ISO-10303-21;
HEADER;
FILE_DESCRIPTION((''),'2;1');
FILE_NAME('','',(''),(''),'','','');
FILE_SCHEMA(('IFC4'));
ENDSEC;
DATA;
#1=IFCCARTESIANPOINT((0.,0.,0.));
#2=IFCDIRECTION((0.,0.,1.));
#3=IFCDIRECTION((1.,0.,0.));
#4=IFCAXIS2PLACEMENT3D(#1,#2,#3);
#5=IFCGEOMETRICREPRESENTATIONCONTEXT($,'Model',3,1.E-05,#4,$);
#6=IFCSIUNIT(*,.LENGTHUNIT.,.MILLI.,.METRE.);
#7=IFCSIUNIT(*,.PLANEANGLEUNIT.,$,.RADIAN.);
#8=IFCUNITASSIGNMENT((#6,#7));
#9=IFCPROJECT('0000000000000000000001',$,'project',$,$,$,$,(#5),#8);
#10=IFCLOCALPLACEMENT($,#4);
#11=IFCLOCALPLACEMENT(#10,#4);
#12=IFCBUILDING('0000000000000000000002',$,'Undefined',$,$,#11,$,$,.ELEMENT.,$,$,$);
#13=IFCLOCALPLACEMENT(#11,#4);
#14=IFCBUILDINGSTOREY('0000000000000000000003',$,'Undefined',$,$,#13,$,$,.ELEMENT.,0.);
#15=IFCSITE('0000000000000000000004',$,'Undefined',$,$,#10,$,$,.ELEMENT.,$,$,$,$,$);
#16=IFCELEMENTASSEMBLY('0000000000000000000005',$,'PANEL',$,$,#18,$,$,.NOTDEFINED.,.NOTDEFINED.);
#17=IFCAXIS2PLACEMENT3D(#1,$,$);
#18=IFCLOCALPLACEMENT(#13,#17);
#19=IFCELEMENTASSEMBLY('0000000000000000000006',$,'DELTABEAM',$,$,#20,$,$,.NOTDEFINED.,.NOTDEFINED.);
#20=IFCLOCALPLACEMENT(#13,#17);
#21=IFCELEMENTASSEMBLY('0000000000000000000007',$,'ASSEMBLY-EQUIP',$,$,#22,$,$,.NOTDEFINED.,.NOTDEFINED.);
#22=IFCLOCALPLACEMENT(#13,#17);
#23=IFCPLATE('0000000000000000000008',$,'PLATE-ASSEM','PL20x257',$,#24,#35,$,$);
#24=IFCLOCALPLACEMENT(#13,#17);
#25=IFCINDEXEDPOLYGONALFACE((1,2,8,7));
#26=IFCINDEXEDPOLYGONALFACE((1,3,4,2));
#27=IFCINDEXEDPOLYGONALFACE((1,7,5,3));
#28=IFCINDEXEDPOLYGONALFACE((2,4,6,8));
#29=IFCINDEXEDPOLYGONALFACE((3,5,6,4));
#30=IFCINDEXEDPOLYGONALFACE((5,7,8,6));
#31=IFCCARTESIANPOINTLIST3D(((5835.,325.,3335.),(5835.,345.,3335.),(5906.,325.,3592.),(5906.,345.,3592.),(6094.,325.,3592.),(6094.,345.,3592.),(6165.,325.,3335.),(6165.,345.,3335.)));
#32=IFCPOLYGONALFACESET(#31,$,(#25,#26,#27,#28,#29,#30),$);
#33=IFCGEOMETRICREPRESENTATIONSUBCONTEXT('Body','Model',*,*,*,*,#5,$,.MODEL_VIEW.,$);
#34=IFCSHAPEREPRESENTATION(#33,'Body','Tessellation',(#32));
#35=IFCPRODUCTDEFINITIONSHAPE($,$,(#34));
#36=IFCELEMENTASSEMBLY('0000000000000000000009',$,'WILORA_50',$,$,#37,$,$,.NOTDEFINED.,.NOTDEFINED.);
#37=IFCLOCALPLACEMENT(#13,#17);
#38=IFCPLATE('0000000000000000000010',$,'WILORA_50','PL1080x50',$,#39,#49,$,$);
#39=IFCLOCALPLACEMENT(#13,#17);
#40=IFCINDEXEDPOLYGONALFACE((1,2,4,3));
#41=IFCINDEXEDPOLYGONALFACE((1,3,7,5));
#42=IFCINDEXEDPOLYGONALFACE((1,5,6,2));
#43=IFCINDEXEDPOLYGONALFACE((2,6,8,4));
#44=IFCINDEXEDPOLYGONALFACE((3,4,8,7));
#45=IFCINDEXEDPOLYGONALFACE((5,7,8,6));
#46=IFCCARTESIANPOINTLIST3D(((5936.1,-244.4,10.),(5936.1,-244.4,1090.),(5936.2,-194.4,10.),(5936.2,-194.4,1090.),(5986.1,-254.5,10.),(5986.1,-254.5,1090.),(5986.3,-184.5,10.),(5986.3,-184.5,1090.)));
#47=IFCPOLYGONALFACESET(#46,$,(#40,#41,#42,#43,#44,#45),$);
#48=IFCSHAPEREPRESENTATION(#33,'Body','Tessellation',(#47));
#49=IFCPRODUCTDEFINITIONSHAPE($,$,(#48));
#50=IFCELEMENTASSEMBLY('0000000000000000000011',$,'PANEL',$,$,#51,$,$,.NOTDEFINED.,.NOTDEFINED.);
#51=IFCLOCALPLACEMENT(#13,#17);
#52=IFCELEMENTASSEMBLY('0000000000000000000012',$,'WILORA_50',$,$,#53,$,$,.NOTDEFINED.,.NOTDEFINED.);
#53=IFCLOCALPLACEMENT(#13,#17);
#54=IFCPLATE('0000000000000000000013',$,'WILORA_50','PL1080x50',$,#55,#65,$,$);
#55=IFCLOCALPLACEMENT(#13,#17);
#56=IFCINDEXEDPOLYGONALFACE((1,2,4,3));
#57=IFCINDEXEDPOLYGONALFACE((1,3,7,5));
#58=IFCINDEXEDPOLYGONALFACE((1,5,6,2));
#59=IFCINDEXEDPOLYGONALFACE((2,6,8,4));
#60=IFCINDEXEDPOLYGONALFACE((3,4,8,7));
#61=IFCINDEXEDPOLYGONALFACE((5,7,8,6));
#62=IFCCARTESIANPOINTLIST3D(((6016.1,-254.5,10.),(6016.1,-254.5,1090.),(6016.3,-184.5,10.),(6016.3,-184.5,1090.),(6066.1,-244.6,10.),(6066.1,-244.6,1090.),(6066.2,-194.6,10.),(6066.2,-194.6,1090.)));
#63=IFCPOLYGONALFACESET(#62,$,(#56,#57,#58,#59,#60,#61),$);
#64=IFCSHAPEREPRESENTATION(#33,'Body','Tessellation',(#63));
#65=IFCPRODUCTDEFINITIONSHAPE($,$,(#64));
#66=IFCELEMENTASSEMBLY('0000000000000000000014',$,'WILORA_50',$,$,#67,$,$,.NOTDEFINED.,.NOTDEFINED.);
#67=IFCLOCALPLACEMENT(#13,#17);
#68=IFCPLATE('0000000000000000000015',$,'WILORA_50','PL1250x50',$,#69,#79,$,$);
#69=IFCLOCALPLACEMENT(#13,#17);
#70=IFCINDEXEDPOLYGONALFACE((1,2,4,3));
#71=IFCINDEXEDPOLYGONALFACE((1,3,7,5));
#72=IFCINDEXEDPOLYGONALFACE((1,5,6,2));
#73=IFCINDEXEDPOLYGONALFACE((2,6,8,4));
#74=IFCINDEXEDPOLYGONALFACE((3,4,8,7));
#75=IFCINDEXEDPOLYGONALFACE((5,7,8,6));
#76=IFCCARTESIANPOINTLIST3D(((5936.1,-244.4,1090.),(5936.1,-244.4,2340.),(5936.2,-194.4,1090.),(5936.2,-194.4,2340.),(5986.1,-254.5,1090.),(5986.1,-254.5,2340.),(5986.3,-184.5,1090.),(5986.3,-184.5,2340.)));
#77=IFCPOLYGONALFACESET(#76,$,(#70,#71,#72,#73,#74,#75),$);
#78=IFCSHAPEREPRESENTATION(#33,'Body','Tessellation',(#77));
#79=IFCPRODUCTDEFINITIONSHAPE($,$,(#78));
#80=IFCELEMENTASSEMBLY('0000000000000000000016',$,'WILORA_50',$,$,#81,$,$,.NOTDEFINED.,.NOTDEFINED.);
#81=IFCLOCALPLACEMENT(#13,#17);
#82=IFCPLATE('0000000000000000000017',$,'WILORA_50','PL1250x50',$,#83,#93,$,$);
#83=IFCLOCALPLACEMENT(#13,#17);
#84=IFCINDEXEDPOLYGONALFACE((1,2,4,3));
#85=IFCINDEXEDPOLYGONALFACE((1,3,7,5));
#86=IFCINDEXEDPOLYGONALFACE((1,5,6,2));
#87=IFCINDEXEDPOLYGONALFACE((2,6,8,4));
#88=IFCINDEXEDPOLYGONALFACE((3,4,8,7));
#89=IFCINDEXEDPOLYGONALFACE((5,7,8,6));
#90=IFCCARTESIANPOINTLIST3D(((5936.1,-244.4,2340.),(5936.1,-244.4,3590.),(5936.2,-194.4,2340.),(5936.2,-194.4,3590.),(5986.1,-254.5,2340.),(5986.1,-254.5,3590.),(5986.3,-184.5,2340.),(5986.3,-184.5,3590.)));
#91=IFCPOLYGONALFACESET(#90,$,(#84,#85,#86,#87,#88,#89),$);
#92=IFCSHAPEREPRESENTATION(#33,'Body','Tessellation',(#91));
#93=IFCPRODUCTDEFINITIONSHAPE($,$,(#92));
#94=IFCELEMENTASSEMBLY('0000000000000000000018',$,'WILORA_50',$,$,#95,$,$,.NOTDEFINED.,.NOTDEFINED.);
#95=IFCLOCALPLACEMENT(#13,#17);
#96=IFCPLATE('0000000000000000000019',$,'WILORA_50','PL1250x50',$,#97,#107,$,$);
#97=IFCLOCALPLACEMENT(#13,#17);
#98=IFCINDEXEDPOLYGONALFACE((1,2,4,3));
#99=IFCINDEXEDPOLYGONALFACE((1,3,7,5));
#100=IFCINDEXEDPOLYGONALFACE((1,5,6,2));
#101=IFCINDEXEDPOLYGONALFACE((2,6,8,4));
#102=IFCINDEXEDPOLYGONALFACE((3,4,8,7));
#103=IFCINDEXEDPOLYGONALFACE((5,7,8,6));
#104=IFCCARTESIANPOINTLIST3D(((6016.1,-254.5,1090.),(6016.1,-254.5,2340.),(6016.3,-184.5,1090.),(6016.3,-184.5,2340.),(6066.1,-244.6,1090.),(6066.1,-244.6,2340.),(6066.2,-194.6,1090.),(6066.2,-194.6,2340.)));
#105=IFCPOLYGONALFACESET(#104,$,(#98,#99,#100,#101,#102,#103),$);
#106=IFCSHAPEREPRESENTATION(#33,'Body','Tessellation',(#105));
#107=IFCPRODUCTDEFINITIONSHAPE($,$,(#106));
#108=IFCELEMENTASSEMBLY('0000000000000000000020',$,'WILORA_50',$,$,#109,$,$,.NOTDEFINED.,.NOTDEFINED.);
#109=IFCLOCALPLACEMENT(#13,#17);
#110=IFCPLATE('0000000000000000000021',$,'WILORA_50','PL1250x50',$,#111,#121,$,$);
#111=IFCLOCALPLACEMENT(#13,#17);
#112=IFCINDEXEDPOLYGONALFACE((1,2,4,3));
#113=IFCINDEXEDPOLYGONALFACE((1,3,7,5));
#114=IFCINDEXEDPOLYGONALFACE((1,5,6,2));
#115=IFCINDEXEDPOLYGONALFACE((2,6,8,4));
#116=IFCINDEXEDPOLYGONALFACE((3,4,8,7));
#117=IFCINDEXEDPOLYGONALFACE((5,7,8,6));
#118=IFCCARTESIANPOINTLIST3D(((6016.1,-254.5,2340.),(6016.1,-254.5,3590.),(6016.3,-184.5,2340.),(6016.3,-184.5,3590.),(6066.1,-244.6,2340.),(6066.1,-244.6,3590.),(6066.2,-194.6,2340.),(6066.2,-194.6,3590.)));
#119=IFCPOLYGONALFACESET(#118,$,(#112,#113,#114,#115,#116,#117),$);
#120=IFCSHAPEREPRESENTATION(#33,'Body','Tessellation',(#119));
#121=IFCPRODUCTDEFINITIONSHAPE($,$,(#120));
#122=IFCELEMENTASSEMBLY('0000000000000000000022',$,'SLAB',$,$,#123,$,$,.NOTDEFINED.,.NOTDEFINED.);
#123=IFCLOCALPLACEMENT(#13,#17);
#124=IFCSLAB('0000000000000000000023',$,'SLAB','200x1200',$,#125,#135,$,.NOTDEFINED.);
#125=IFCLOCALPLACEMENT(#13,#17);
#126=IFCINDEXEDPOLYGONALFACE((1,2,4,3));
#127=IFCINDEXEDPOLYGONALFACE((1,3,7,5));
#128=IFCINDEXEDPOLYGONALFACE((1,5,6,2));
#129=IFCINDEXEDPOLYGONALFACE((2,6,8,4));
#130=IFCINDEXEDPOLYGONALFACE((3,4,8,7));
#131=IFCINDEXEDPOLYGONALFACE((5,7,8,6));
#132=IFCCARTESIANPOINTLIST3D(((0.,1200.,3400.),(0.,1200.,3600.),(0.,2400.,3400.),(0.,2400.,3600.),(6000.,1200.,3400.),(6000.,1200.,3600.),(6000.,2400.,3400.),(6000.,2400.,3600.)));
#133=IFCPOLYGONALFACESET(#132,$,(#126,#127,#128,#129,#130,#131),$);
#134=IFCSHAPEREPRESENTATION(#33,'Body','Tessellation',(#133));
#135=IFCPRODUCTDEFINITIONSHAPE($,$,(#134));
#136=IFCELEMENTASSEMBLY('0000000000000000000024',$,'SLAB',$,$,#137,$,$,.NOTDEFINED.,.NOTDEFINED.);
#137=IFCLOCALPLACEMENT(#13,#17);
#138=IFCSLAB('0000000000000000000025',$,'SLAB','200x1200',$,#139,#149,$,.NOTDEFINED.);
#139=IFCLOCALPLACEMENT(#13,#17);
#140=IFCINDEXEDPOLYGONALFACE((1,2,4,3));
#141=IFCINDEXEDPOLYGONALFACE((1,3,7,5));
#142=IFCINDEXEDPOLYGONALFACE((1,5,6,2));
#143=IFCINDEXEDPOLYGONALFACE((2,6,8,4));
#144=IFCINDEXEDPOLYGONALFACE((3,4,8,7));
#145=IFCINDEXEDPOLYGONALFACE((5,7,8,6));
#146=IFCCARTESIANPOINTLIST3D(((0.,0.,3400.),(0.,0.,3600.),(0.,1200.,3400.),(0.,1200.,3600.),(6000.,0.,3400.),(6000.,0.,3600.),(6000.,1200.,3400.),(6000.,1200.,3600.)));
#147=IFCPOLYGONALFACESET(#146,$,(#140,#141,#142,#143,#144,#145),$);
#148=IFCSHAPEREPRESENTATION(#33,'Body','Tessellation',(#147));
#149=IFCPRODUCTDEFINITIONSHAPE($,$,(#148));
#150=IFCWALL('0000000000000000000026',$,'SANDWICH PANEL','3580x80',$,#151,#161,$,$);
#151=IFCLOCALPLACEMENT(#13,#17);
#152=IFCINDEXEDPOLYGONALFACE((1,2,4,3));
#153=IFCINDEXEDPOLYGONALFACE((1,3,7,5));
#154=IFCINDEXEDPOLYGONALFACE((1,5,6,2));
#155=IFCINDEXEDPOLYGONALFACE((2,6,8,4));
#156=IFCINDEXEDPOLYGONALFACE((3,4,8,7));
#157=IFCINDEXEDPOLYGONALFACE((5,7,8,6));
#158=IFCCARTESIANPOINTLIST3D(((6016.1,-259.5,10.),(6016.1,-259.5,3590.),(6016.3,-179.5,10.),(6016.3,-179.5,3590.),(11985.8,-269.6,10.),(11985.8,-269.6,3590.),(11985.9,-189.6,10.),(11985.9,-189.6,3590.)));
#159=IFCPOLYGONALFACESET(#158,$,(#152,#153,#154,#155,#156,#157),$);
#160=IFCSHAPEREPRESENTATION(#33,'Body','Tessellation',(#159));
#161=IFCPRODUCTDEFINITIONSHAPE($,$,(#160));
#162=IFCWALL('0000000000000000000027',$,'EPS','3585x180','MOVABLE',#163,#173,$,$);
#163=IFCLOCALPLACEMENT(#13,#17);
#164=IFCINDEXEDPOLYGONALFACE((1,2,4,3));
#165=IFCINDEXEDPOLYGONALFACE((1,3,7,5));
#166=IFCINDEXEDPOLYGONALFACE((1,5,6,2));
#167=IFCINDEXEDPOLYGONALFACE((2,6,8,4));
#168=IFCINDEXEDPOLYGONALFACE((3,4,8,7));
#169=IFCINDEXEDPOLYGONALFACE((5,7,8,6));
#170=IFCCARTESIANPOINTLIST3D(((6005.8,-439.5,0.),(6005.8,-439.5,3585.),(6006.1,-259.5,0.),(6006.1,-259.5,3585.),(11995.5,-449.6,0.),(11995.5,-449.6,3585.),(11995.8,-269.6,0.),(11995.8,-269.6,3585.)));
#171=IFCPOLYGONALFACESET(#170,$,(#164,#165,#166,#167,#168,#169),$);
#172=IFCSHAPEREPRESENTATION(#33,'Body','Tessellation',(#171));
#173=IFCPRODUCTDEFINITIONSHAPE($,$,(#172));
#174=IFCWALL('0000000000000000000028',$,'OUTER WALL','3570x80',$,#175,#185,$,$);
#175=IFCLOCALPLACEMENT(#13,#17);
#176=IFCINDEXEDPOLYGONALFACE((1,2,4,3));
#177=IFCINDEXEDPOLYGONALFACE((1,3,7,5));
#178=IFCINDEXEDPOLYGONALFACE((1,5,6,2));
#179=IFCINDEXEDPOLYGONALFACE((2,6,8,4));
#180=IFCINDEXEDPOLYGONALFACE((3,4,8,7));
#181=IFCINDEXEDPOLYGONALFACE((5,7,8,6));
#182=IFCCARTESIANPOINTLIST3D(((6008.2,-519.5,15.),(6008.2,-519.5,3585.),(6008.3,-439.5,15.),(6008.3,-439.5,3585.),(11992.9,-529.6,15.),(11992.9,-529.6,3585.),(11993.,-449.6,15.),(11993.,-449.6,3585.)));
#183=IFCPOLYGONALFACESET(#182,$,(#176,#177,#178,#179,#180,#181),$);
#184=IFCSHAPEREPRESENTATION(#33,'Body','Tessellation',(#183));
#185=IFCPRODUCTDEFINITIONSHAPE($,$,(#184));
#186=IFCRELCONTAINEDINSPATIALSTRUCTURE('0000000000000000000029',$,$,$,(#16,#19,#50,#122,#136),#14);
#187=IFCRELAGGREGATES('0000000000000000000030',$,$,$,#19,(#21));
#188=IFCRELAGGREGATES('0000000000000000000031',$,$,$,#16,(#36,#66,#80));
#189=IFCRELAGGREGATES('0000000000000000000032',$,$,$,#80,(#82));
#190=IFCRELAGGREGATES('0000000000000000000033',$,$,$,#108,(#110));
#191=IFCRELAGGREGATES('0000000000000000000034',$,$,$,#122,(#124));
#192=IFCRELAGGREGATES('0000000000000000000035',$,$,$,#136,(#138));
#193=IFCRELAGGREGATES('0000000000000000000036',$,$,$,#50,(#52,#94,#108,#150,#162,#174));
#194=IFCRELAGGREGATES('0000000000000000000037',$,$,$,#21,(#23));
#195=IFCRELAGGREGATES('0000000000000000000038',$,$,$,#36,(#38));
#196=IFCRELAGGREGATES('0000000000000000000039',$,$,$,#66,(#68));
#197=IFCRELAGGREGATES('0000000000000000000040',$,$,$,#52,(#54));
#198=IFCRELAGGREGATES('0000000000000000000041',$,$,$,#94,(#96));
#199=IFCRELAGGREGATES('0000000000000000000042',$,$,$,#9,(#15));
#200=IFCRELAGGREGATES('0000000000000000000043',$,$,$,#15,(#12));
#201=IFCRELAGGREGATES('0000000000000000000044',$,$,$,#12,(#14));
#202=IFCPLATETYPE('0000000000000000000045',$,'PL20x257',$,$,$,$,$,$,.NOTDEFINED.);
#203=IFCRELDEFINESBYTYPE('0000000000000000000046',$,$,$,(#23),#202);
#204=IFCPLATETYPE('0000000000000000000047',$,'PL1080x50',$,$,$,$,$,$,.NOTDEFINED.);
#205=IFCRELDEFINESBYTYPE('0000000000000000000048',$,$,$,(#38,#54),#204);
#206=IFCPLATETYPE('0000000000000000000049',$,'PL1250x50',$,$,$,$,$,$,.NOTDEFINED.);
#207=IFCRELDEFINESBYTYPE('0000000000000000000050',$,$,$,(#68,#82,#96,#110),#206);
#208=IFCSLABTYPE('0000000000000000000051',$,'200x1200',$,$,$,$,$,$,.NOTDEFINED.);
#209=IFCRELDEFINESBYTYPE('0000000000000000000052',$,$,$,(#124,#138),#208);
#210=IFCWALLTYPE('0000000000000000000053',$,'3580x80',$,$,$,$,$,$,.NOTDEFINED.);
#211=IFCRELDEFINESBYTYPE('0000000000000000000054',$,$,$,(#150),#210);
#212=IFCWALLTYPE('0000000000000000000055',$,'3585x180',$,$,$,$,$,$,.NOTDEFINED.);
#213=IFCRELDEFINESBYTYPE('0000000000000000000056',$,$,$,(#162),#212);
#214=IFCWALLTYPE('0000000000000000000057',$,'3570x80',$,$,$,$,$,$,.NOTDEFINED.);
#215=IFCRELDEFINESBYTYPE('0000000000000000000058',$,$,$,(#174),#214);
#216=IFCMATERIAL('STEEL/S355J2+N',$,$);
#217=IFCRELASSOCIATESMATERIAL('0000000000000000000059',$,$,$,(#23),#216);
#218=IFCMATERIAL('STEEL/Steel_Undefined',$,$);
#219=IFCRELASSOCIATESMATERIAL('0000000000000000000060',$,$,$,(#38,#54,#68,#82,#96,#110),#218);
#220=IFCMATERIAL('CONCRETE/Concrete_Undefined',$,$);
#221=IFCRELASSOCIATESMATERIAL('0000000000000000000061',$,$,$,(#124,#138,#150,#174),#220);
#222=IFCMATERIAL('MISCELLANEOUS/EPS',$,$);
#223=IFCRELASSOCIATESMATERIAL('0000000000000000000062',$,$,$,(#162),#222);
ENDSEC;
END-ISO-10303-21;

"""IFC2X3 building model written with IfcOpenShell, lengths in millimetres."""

from ifc_helpers import new_model, si_unit, frame, frame_2d, origin_with_axes, place, context, subcontext, project, spatial, polyline, rectangle, outline, extrude, material, type_object, element, aggregate, save


model = new_model("IFC2X3")

# Units and contexts
model_context = context("Model", 3, precision=1e-05, world=origin_with_axes())
body_context = subcontext(model_context, "Body", "Model", "MODEL_VIEW")
ifc_project = project(units=[si_unit("LENGTHUNIT", "METRE", prefix="MILLI"), si_unit("PLANEANGLEUNIT", "RADIAN")], contexts=[model_context])

# Site, building, storey
site_placement = place(None, origin_with_axes())
site = spatial("IfcSite", under=ifc_project, at=site_placement, Name="Undefined", CompositionType="ELEMENT")
building_placement = place(site_placement, origin_with_axes())
building = spatial("IfcBuilding", under=site, at=building_placement, Name="Undefined", CompositionType="ELEMENT")
storey_placement = place(building_placement, origin_with_axes())
storey = spatial("IfcBuildingStorey", under=building, at=storey_placement, Name="Undefined", CompositionType="ELEMENT", Elevation=0.0)

# Shared definitions
ifc_material_1 = material(Name="CONCRETE/Concrete_Undefined")

# Element assembly
assembly_1_placement = place(storey_placement, origin_with_axes())
assembly_1 = element("IfcElementAssembly", 1, at=assembly_1_placement, inside=storey, Name="PANEL", AssemblyPlace="NOTDEFINED", PredefinedType="NOTDEFINED")
ifc_material_2 = material(Name="STEEL/Steel_Undefined")

# Element assembly
assembly_2_placement = place(storey_placement, origin_with_axes())
assembly_2 = element("IfcElementAssembly", 2, at=assembly_2_placement, inside=storey, Name="DELTABEAM", AssemblyPlace="NOTDEFINED", PredefinedType="NOTDEFINED")

# Shared definitions
ifc_material_3 = material(Name="STEEL/S355J2+N")
plate_type_1 = type_object("IfcPlateType", Name="PL20x257", PredefinedType="NOTDEFINED")

# Element assembly
assembly_3_placement = place(assembly_2_placement, origin_with_axes())
assembly_3 = element("IfcElementAssembly", 3, at=assembly_3_placement, Name="ASSEMBLY-EQUIP", AssemblyPlace="NOTDEFINED", PredefinedType="NOTDEFINED")
aggregate(assembly_2, [assembly_3])

# Plate
plate_1_placement = place(assembly_3_placement, frame((6165.0, 335.0, 3335.0), z_axis=(0.0, 1.0, 0.0), x_axis=(-1.0, 0.0, 0.0)))
plate_1 = element("IfcPlate", 4, at=plate_1_placement, type_object=plate_type_1, material=ifc_material_3, Name="PLATE-ASSEM", Description="PL20x257", context=body_context, shape_type="SweptSolid", body=[
    extrude(outline(polyline([(0.0, 0.0), (330.0, 0.0), (259.0, 257.0), (71.0, 257.0), (0.0, 0.0)])), frame((0.0, 0.0, -10.0), z_axis=(0.0, 0.0, 1.0), x_axis=(1.0, 0.0, 0.0)), (0.0, 0.0, 1.0), 20.0),
])

# Element assembly, plate
assembly_4_placement = place(assembly_1_placement, origin_with_axes())
assembly_4 = element("IfcElementAssembly", 5, at=assembly_4_placement, Name="WILORA_50", AssemblyPlace="NOTDEFINED", PredefinedType="NOTDEFINED")
plate_type_2 = type_object("IfcPlateType", Name="PL1080x50", PredefinedType="NOTDEFINED")
plate_2_placement = place(assembly_4_placement, frame((5986.1, -254.5, 550.0), z_axis=(0.0, 0.0, 1.0), x_axis=(0.001684, 0.999999, 0.0)))
plate_2 = element("IfcPlate", 6, at=plate_2_placement, type_object=plate_type_2, material=ifc_material_2, Name="WILORA_50", Description="PL1080x50", context=body_context, shape_type="SweptSolid", body=[
    extrude(outline(polyline([(0.0, 0.0), (70.0, 0.0), (60.0, 50.0), (10.0, 50.0), (0.0, 0.0)])), frame((0.0, 0.0, -540.0), z_axis=(0.0, 0.0, 1.0), x_axis=(1.0, 0.0, 0.0)), (0.0, 0.0, 1.0), 1080.0),
])

# Element assemblies, plate
assembly_5_placement = place(storey_placement, origin_with_axes())
assembly_5 = element("IfcElementAssembly", 7, at=assembly_5_placement, inside=storey, Name="PANEL", AssemblyPlace="NOTDEFINED", PredefinedType="NOTDEFINED")
assembly_6_placement = place(assembly_5_placement, origin_with_axes())
assembly_6 = element("IfcElementAssembly", 8, at=assembly_6_placement, Name="WILORA_50", AssemblyPlace="NOTDEFINED", PredefinedType="NOTDEFINED")
plate_3_placement = place(assembly_6_placement, frame((6016.3, -184.5, 550.0), z_axis=(0.0, 0.0, 1.0), x_axis=(-0.001684, -0.999999, 0.0)))
plate_3 = element("IfcPlate", 9, at=plate_3_placement, type_object=plate_type_2, material=ifc_material_2, Name="WILORA_50", Description="PL1080x50", context=body_context, shape_type="SweptSolid", body=[
    extrude(outline(polyline([(0.0, 0.0), (70.0, 0.0), (60.0, 50.0), (10.0, 50.0), (0.0, 0.0)])), frame((0.0, 0.0, -540.0), z_axis=(0.0, 0.0, 1.0), x_axis=(1.0, 0.0, 0.0)), (0.0, 0.0, 1.0), 1080.0),
])

# Element assembly, plate
assembly_7_placement = place(assembly_1_placement, origin_with_axes())
assembly_7 = element("IfcElementAssembly", 10, at=assembly_7_placement, Name="WILORA_50", AssemblyPlace="NOTDEFINED", PredefinedType="NOTDEFINED")
plate_type_3 = type_object("IfcPlateType", Name="PL1250x50", PredefinedType="NOTDEFINED")
plate_4_placement = place(assembly_7_placement, frame((5986.1, -254.5, 1715.0), z_axis=(0.0, 0.0, 1.0), x_axis=(0.001684, 0.999999, 0.0)))
plate_4 = element("IfcPlate", 11, at=plate_4_placement, type_object=plate_type_3, material=ifc_material_2, Name="WILORA_50", Description="PL1250x50", context=body_context, shape_type="SweptSolid", body=[
    extrude(outline(polyline([(0.0, 0.0), (70.0, 0.0), (60.0, 50.0), (10.0, 50.0), (0.0, 0.0)])), frame((0.0, 0.0, -625.0), z_axis=(0.0, 0.0, 1.0), x_axis=(1.0, 0.0, 0.0)), (0.0, 0.0, 1.0), 1250.0),
])

# Element assembly
assembly_8_placement = place(assembly_1_placement, origin_with_axes())
assembly_8 = element("IfcElementAssembly", 12, at=assembly_8_placement, Name="WILORA_50", AssemblyPlace="NOTDEFINED", PredefinedType="NOTDEFINED")
aggregate(assembly_1, [assembly_4, assembly_7, assembly_8])

# Plate
plate_5_placement = place(assembly_8_placement, frame((5986.1, -254.5, 2965.0), z_axis=(0.0, 0.0, 1.0), x_axis=(0.001684, 0.999999, 0.0)))
plate_5 = element("IfcPlate", 13, at=plate_5_placement, type_object=plate_type_3, material=ifc_material_2, Name="WILORA_50", Description="PL1250x50", context=body_context, shape_type="SweptSolid", body=[
    extrude(outline(polyline([(0.0, 0.0), (70.0, 0.0), (60.0, 50.0), (10.0, 50.0), (0.0, 0.0)])), frame((0.0, 0.0, -625.0), z_axis=(0.0, 0.0, 1.0), x_axis=(1.0, 0.0, 0.0)), (0.0, 0.0, 1.0), 1250.0),
])
aggregate(assembly_8, [plate_5])

# Element assemblies, plates
assembly_9_placement = place(assembly_5_placement, origin_with_axes())
assembly_9 = element("IfcElementAssembly", 14, at=assembly_9_placement, Name="WILORA_50", AssemblyPlace="NOTDEFINED", PredefinedType="NOTDEFINED")
plate_6_placement = place(assembly_9_placement, frame((6016.3, -184.5, 1715.0), z_axis=(0.0, 0.0, 1.0), x_axis=(-0.001684, -0.999999, 0.0)))
plate_6 = element("IfcPlate", 15, at=plate_6_placement, type_object=plate_type_3, material=ifc_material_2, Name="WILORA_50", Description="PL1250x50", context=body_context, shape_type="SweptSolid", body=[
    extrude(outline(polyline([(0.0, 0.0), (70.0, 0.0), (60.0, 50.0), (10.0, 50.0), (0.0, 0.0)])), frame((0.0, 0.0, -625.0), z_axis=(0.0, 0.0, 1.0), x_axis=(1.0, 0.0, 0.0)), (0.0, 0.0, 1.0), 1250.0),
])
assembly_10_placement = place(assembly_5_placement, origin_with_axes())
assembly_10 = element("IfcElementAssembly", 16, at=assembly_10_placement, Name="WILORA_50", AssemblyPlace="NOTDEFINED", PredefinedType="NOTDEFINED")
plate_7_placement = place(assembly_10_placement, frame((6016.3, -184.5, 2965.0), z_axis=(0.0, 0.0, 1.0), x_axis=(-0.001684, -0.999999, 0.0)))
plate_7 = element("IfcPlate", 17, at=plate_7_placement, type_object=plate_type_3, material=ifc_material_2, Name="WILORA_50", Description="PL1250x50", context=body_context, shape_type="SweptSolid", body=[
    extrude(outline(polyline([(0.0, 0.0), (70.0, 0.0), (60.0, 50.0), (10.0, 50.0), (0.0, 0.0)])), frame((0.0, 0.0, -625.0), z_axis=(0.0, 0.0, 1.0), x_axis=(1.0, 0.0, 0.0)), (0.0, 0.0, 1.0), 1250.0),
])
aggregate(assembly_10, [plate_7])

# Element assemblies, slabs
assembly_11_placement = place(storey_placement, origin_with_axes())
assembly_11 = element("IfcElementAssembly", 18, at=assembly_11_placement, inside=storey, Name="SLAB", AssemblyPlace="NOTDEFINED", PredefinedType="NOTDEFINED")
slab_type = type_object("IfcSlabType", Name="200x1200", PredefinedType="NOTDEFINED")
slab_1_placement = place(assembly_11_placement, frame((6000.0, 1200.0, 3500.0), z_axis=(0.0, 0.0, 1.0), x_axis=(0.0, 1.0, 0.0)))
slab_1 = element("IfcSlab", 19, at=slab_1_placement, type_object=slab_type, material=ifc_material_1, Name="SLAB", Description="200x1200", PredefinedType="NOTDEFINED", context=body_context, shape_type="SweptSolid", body=[
    extrude(outline(polyline([(0.0, 0.0), (1200.0, 0.0), (1200.0, 6000.0), (0.0, 6000.0), (0.0, 0.0)])), frame((0.0, 0.0, -100.0), z_axis=(0.0, 0.0, 1.0), x_axis=(1.0, 0.0, 0.0)), (0.0, 0.0, 1.0), 200.0),
])
aggregate(assembly_11, [slab_1])
assembly_12_placement = place(storey_placement, origin_with_axes())
assembly_12 = element("IfcElementAssembly", 20, at=assembly_12_placement, inside=storey, Name="SLAB", AssemblyPlace="NOTDEFINED", PredefinedType="NOTDEFINED")
slab_2_placement = place(assembly_12_placement, frame((6000.0, 0.0, 3500.0), z_axis=(0.0, 0.0, 1.0), x_axis=(0.0, 1.0, 0.0)))
slab_2 = element("IfcSlab", 21, at=slab_2_placement, type_object=slab_type, material=ifc_material_1, Name="SLAB", Description="200x1200", PredefinedType="NOTDEFINED", context=body_context, shape_type="SweptSolid", body=[
    extrude(outline(polyline([(0.0, 0.0), (1200.0, 0.0), (1200.0, 6000.0), (0.0, 6000.0), (0.0, 0.0)])), frame((0.0, 0.0, -100.0), z_axis=(0.0, 0.0, 1.0), x_axis=(1.0, 0.0, 0.0)), (0.0, 0.0, 1.0), 200.0),
])
aggregate(assembly_12, [slab_2])

# Walls
wall_type_1 = type_object("IfcWallType", Name="3580x80", PredefinedType="NOTDEFINED")
wall_1_placement = place(assembly_5_placement, frame((6016.2, -219.5, 10.0), z_axis=(0.0, 0.0, 1.0), x_axis=(0.999999, -0.001684, 0.0)))
wall_1 = element("IfcWall", 22, at=wall_1_placement, type_object=wall_type_1, material=ifc_material_1, Name="SANDWICH PANEL", Description="3580x80", context=body_context, shape_type="SweptSolid", body=[
    extrude(rectangle(XDim=5969.7, YDim=80.0, at=frame_2d((0.0, 2984.8), x_axis=(0.0, -1.0))), frame((0.0, 0.0, 0.0), z_axis=(0.0, 0.0, 1.0), x_axis=(0.0, -1.0, 0.0)), (0.0, 0.0, 1.0), 3580.0),
])
ifc_material_4 = material(Name="MISCELLANEOUS/EPS")
wall_type_2 = type_object("IfcWallType", Name="3585x180", PredefinedType="NOTDEFINED")
wall_2_placement = place(assembly_5_placement, frame((6006.0, -349.5, 0.0), z_axis=(0.0, 0.0, 1.0), x_axis=(0.999999, -0.001684, 0.0)))
wall_2 = element("IfcWall", 23, at=wall_2_placement, type_object=wall_type_2, material=ifc_material_4, Name="EPS", Description="3585x180", ObjectType="MOVABLE", context=body_context, shape_type="SweptSolid", body=[
    extrude(rectangle(XDim=5989.7, YDim=180.0, at=frame_2d((0.0, 2994.8), x_axis=(0.0, -1.0))), frame((0.0, 0.0, 0.0), z_axis=(0.0, 0.0, 1.0), x_axis=(0.0, -1.0, 0.0)), (0.0, 0.0, 1.0), 3585.0),
])
wall_type_3 = type_object("IfcWallType", Name="3570x80", PredefinedType="NOTDEFINED")
wall_3_placement = place(assembly_5_placement, frame((6008.3, -479.5, 15.0), z_axis=(0.0, 0.0, 1.0), x_axis=(0.999999, -0.001684, 0.0)))
wall_3 = element("IfcWall", 24, at=wall_3_placement, type_object=wall_type_3, material=ifc_material_1, Name="OUTER WALL", Description="3570x80", context=body_context, shape_type="SweptSolid", body=[
    extrude(rectangle(XDim=5984.7, YDim=80.0, at=frame_2d((0.0, 2992.3), x_axis=(0.0, -1.0))), frame((0.0, 0.0, 0.0), z_axis=(0.0, 0.0, 1.0), x_axis=(0.0, -1.0, 0.0)), (0.0, 0.0, 1.0), 3570.0),
])

aggregate(assembly_5, [assembly_6, assembly_9, assembly_10, wall_1, wall_2, wall_3])

aggregate(assembly_3, [plate_1])

aggregate(assembly_4, [plate_2])
aggregate(assembly_7, [plate_4])
aggregate(assembly_6, [plate_3])
aggregate(assembly_9, [plate_6])

save(model, "model.ifc")
